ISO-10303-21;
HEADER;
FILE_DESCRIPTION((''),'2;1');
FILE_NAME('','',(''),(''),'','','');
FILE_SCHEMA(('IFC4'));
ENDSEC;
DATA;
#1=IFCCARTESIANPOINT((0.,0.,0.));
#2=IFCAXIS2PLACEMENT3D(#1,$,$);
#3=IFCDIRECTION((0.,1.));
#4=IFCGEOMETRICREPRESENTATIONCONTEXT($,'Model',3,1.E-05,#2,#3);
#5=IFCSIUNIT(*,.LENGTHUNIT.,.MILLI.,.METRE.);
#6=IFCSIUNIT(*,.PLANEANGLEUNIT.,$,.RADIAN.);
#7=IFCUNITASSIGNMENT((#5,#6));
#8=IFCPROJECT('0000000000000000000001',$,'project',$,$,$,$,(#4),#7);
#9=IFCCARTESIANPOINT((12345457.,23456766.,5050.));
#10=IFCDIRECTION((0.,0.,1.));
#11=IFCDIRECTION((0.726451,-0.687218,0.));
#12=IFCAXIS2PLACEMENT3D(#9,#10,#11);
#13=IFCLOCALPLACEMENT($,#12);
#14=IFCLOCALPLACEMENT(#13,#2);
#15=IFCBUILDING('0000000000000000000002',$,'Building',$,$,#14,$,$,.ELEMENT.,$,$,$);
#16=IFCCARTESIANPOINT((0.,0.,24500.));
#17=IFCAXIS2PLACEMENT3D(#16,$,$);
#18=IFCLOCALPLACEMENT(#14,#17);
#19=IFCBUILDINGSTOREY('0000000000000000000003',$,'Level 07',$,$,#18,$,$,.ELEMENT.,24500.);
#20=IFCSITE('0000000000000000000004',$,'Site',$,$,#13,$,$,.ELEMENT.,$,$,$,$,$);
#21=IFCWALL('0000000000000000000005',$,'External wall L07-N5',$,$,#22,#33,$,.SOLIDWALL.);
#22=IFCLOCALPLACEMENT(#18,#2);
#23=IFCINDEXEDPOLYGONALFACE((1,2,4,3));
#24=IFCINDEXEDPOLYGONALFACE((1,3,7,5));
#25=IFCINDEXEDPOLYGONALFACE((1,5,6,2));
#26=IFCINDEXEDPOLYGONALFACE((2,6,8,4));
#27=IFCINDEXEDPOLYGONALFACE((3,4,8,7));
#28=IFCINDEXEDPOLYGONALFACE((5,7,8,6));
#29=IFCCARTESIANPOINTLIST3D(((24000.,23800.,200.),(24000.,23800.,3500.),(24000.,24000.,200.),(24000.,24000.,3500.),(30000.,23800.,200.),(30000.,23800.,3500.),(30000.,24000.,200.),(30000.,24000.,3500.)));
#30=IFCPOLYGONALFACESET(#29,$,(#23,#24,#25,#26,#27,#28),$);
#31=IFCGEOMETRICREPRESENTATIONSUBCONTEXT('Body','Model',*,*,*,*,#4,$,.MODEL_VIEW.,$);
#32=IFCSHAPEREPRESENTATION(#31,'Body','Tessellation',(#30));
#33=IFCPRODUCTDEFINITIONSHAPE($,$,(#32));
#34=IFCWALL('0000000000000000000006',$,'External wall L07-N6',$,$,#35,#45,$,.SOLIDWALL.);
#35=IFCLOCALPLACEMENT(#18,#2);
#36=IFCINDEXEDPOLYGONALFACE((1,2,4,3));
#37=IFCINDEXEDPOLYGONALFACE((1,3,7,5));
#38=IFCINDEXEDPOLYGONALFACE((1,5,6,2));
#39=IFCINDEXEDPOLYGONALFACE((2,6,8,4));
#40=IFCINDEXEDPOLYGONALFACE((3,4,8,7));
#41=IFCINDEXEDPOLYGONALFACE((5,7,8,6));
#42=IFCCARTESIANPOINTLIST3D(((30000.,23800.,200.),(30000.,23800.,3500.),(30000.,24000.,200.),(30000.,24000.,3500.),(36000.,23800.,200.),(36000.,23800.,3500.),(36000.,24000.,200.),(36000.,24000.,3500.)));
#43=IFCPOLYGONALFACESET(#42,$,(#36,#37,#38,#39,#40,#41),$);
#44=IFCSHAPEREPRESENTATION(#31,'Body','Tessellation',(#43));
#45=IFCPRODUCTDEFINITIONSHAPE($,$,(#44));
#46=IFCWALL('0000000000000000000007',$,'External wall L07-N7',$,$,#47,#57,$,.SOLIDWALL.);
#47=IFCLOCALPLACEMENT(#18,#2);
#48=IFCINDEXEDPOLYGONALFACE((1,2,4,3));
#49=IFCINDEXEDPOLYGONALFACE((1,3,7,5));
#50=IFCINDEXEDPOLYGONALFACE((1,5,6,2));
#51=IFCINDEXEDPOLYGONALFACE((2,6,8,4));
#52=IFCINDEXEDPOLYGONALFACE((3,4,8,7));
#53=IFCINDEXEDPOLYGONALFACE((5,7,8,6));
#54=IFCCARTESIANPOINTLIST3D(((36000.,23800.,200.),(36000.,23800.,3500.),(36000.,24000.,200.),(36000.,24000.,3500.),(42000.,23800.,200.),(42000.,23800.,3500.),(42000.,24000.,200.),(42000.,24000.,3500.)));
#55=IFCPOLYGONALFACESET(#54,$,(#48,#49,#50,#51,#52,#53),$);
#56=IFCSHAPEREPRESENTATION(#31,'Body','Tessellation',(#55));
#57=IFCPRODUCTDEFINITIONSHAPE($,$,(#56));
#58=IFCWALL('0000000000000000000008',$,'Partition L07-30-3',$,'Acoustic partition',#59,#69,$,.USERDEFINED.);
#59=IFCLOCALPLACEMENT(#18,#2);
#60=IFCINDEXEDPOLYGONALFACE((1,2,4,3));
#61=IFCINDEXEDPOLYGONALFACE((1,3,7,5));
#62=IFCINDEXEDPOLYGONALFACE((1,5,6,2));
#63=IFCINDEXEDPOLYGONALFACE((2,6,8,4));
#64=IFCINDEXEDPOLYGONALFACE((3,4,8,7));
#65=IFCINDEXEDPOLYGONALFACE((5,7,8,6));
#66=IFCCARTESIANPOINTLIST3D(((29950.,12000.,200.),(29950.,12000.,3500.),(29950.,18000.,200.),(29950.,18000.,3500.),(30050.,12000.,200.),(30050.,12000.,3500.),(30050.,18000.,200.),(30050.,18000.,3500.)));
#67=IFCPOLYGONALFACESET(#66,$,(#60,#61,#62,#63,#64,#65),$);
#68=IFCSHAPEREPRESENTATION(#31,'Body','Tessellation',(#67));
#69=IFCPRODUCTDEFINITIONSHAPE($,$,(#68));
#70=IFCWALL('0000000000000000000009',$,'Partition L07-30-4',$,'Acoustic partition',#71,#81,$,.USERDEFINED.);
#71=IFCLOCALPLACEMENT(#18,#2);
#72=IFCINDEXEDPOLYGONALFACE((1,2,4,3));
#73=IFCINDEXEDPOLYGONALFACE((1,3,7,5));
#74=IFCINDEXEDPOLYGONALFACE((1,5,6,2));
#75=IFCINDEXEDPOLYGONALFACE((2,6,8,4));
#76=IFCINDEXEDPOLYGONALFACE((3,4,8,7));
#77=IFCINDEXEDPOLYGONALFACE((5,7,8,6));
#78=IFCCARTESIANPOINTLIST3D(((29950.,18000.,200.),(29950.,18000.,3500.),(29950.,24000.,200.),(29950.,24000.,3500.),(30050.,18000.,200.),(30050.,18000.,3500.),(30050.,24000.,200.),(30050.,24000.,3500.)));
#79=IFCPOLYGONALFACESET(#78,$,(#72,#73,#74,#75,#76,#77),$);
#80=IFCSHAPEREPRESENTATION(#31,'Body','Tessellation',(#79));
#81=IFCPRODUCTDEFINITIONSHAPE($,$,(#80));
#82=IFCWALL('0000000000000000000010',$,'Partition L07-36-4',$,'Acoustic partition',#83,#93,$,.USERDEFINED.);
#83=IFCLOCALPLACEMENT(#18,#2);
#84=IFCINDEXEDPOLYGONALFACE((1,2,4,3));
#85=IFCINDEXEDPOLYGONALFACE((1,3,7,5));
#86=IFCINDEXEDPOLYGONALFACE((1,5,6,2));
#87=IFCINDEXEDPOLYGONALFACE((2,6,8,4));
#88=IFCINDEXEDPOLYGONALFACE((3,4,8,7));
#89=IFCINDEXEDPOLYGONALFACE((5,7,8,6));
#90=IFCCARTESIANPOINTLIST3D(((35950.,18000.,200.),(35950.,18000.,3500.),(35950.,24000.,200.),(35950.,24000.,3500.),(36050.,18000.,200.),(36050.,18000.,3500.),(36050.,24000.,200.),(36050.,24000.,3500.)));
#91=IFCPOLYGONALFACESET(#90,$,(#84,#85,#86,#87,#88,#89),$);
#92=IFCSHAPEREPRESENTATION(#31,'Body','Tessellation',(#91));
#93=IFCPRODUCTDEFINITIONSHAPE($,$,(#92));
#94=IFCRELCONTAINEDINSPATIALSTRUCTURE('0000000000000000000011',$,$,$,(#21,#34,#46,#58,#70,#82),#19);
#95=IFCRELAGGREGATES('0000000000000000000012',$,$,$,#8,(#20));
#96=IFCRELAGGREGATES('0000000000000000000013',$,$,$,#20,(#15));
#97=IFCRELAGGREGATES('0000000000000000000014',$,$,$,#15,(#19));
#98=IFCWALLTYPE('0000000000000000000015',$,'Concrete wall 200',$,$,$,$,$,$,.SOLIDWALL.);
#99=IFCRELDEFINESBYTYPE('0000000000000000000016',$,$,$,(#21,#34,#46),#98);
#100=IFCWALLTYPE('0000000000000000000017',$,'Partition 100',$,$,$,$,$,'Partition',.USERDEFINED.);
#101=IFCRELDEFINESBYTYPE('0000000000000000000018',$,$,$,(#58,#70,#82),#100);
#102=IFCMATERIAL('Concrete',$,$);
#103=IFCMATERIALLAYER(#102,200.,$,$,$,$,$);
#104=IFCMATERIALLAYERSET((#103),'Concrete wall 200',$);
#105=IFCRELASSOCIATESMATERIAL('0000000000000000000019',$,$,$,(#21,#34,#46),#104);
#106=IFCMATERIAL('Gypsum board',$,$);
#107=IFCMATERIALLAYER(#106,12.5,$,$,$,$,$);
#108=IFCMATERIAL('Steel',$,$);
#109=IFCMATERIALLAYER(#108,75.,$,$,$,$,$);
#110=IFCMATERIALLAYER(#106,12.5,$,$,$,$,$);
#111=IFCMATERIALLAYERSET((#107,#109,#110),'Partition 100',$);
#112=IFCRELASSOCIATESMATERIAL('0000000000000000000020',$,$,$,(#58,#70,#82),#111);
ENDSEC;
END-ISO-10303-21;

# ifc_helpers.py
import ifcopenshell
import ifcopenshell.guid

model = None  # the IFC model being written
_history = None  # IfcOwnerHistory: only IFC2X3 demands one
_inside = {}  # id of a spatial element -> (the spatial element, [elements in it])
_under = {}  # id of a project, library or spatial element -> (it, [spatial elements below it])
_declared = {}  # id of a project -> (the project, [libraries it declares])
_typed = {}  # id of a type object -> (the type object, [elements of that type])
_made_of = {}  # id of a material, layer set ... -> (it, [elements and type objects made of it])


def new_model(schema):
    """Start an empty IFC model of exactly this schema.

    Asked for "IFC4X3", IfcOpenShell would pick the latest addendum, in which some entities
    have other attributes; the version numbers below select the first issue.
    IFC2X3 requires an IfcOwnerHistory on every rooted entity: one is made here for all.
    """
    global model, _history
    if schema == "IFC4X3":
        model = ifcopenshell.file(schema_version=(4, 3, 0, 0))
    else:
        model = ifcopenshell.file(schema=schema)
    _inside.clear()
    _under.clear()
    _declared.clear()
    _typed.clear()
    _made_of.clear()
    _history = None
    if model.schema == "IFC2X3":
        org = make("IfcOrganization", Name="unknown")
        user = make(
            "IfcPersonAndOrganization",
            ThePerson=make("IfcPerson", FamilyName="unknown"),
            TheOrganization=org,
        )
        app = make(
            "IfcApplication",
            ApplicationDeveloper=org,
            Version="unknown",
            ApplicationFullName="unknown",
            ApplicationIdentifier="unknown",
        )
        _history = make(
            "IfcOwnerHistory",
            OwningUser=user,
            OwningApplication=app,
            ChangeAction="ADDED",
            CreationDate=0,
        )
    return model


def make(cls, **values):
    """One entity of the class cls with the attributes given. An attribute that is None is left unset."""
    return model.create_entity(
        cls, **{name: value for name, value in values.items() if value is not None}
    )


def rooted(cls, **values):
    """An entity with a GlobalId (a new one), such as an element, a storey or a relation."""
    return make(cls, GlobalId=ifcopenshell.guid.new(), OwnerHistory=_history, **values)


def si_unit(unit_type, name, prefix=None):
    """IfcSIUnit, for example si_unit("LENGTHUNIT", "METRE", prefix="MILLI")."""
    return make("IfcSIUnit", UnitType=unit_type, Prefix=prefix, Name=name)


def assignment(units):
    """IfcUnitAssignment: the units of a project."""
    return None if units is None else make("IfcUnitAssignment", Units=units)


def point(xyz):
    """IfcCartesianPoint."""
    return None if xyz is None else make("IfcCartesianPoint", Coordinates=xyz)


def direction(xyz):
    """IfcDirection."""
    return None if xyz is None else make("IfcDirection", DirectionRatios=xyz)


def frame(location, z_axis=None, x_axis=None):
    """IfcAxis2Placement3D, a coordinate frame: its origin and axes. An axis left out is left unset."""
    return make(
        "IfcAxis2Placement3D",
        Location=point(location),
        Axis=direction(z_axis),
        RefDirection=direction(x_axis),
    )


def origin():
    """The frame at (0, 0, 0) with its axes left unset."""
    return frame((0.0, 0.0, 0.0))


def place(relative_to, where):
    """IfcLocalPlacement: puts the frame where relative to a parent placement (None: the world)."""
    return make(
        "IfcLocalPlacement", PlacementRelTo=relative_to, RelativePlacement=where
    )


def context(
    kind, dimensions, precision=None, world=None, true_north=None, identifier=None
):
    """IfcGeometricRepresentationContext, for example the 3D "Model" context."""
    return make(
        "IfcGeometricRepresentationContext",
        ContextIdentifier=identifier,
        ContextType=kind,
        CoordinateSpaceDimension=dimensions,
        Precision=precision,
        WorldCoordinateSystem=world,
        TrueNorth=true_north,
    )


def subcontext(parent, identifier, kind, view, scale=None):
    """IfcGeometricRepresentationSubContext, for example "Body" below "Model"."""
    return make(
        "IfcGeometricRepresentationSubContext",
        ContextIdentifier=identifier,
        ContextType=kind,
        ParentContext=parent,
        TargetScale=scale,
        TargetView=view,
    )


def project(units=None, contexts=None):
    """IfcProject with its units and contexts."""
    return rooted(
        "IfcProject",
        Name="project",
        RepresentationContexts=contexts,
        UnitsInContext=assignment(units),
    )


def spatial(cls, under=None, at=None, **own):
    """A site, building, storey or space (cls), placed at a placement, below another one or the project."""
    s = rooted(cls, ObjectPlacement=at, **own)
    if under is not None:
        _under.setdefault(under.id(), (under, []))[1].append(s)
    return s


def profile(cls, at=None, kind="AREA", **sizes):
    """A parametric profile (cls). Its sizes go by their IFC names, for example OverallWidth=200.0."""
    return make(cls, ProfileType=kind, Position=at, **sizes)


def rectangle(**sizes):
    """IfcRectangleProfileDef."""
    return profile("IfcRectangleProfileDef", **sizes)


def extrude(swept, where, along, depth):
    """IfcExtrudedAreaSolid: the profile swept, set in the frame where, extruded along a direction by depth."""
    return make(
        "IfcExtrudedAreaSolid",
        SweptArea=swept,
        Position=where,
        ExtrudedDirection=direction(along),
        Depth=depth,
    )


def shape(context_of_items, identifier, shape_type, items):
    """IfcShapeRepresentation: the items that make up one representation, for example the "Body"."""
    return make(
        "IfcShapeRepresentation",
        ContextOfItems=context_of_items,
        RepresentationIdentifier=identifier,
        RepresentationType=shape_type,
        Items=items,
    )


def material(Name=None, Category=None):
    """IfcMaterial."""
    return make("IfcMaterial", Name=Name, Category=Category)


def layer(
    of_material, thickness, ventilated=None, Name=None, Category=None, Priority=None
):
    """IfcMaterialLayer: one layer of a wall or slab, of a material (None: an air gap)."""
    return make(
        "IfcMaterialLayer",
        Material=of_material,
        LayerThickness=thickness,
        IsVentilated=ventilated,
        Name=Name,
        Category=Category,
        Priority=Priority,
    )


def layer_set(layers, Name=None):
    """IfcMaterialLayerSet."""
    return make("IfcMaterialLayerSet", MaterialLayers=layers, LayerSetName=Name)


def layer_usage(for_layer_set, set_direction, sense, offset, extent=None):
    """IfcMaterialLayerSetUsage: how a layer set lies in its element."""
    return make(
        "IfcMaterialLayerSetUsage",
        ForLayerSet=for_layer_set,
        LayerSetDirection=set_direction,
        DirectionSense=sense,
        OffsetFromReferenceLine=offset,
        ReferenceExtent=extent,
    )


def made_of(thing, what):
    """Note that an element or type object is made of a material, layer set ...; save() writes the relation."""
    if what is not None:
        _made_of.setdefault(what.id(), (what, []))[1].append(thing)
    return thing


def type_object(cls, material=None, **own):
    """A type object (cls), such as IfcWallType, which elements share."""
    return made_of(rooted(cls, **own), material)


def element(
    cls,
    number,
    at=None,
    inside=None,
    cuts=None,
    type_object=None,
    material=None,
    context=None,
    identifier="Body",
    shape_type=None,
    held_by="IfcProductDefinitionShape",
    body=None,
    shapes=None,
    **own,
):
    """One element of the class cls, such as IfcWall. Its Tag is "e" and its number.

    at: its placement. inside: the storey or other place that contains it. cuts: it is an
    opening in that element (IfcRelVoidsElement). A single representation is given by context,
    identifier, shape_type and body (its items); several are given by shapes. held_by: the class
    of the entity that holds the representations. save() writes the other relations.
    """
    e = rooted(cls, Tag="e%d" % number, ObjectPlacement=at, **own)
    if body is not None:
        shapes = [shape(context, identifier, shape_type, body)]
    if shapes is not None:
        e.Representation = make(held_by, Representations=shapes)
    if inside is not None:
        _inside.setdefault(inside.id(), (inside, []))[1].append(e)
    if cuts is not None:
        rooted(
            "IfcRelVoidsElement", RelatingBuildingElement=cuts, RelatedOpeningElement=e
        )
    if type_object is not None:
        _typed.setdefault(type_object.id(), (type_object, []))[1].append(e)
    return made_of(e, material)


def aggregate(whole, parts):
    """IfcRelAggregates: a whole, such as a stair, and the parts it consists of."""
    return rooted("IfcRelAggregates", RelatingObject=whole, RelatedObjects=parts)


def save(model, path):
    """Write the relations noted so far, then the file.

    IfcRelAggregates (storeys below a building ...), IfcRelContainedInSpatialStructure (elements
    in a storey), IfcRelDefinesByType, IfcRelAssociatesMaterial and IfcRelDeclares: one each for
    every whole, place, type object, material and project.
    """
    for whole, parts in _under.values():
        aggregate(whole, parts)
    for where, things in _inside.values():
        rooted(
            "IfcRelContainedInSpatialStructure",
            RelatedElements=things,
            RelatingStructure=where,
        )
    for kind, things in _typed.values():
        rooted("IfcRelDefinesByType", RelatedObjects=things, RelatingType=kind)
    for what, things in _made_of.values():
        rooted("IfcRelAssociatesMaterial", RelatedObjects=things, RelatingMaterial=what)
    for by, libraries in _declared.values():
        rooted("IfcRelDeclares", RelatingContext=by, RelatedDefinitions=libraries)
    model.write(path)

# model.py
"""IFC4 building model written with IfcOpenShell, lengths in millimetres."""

from ifc_helpers import new_model, si_unit, direction, frame, origin, place, context, subcontext, project, spatial, rectangle, extrude, material, layer, layer_set, layer_usage, type_object, element, save


model = new_model("IFC4")

# Units and contexts
model_context = context("Model", 3, precision=1e-05, world=origin(), true_north=direction((0.0, 1.0)))
body_context = subcontext(model_context, "Body", "Model", "MODEL_VIEW")
ifc_project = project(units=[si_unit("LENGTHUNIT", "METRE", prefix="MILLI"), si_unit("PLANEANGLEUNIT", "RADIAN")], contexts=[model_context])

# Site, building, storey
site_placement = place(None, frame((12345457.0, 23456766.0, 5050.0), z_axis=(0.0, 0.0, 1.0), x_axis=(0.726451, -0.687218, 0.0)))
site = spatial("IfcSite", under=ifc_project, at=site_placement, Name="Site", CompositionType="ELEMENT")
building_placement = place(site_placement, origin())
building = spatial("IfcBuilding", under=site, at=building_placement, Name="Building", CompositionType="ELEMENT")
storey_placement = place(building_placement, frame((0.0, 0.0, 24500.0)))
storey = spatial("IfcBuildingStorey", under=building, at=storey_placement, Name="Level 07", CompositionType="ELEMENT", Elevation=24500.0)

# Shared definitions
ifc_material_1 = material(Name="Steel")

# Shared definitions
ifc_material_2 = material(Name="Concrete")

# Walls
ifc_layer_1 = layer(ifc_material_2, 200.0)
ifc_layer_set_1 = layer_set([ifc_layer_1], Name="Concrete wall 200")
ifc_layer_usage_1 = layer_usage(ifc_layer_set_1, "AXIS2", "POSITIVE", 0.0)
wall_type_1 = type_object("IfcWallType", Name="Concrete wall 200", PredefinedType="SOLIDWALL")
for number, where, name in (
    (1, (24000.0, 23800.0, 200.0), "External wall L07-N5"),
    (2, (30000.0, 23800.0, 200.0), "External wall L07-N6"),
    (3, (36000.0, 23800.0, 200.0), "External wall L07-N7"),
):
    element("IfcWall", number, at=place(storey_placement, frame(where)), inside=storey, type_object=wall_type_1, material=ifc_layer_usage_1, Name=name, PredefinedType="SOLIDWALL", context=body_context, shape_type="SweptSolid", body=[
        extrude(rectangle(XDim=6000.0, YDim=200.0), frame((3000.0, 100.0, 0.0)), (0.0, 0.0, 1.0), 3300.0),
    ])
ifc_material_3 = material(Name="Gypsum board")
ifc_layer_2 = layer(ifc_material_3, 12.5)
ifc_layer_3 = layer(ifc_material_1, 75.0)
ifc_layer_4 = layer(ifc_material_3, 12.5)
ifc_layer_set_2 = layer_set([ifc_layer_2, ifc_layer_3, ifc_layer_4], Name="Partition 100")
ifc_layer_usage_2 = layer_usage(ifc_layer_set_2, "AXIS2", "POSITIVE", 0.0)
wall_type_2 = type_object("IfcWallType", Name="Partition 100", ElementType="Partition", PredefinedType="USERDEFINED")
for number, where, name in (
    (4, (29950.0, 12000.0, 200.0), "Partition L07-30-3"),
    (5, (29950.0, 18000.0, 200.0), "Partition L07-30-4"),
    (6, (35950.0, 18000.0, 200.0), "Partition L07-36-4"),
):
    element("IfcWall", number, at=place(storey_placement, frame(where)), inside=storey, type_object=wall_type_2, material=ifc_layer_usage_2, Name=name, ObjectType="Acoustic partition", PredefinedType="USERDEFINED", context=body_context, shape_type="SweptSolid", body=[
        extrude(rectangle(XDim=100.0, YDim=6000.0), frame((50.0, 3000.0, 0.0)), (0.0, 0.0, 1.0), 3300.0),
    ])

save(model, "model.ifc")
